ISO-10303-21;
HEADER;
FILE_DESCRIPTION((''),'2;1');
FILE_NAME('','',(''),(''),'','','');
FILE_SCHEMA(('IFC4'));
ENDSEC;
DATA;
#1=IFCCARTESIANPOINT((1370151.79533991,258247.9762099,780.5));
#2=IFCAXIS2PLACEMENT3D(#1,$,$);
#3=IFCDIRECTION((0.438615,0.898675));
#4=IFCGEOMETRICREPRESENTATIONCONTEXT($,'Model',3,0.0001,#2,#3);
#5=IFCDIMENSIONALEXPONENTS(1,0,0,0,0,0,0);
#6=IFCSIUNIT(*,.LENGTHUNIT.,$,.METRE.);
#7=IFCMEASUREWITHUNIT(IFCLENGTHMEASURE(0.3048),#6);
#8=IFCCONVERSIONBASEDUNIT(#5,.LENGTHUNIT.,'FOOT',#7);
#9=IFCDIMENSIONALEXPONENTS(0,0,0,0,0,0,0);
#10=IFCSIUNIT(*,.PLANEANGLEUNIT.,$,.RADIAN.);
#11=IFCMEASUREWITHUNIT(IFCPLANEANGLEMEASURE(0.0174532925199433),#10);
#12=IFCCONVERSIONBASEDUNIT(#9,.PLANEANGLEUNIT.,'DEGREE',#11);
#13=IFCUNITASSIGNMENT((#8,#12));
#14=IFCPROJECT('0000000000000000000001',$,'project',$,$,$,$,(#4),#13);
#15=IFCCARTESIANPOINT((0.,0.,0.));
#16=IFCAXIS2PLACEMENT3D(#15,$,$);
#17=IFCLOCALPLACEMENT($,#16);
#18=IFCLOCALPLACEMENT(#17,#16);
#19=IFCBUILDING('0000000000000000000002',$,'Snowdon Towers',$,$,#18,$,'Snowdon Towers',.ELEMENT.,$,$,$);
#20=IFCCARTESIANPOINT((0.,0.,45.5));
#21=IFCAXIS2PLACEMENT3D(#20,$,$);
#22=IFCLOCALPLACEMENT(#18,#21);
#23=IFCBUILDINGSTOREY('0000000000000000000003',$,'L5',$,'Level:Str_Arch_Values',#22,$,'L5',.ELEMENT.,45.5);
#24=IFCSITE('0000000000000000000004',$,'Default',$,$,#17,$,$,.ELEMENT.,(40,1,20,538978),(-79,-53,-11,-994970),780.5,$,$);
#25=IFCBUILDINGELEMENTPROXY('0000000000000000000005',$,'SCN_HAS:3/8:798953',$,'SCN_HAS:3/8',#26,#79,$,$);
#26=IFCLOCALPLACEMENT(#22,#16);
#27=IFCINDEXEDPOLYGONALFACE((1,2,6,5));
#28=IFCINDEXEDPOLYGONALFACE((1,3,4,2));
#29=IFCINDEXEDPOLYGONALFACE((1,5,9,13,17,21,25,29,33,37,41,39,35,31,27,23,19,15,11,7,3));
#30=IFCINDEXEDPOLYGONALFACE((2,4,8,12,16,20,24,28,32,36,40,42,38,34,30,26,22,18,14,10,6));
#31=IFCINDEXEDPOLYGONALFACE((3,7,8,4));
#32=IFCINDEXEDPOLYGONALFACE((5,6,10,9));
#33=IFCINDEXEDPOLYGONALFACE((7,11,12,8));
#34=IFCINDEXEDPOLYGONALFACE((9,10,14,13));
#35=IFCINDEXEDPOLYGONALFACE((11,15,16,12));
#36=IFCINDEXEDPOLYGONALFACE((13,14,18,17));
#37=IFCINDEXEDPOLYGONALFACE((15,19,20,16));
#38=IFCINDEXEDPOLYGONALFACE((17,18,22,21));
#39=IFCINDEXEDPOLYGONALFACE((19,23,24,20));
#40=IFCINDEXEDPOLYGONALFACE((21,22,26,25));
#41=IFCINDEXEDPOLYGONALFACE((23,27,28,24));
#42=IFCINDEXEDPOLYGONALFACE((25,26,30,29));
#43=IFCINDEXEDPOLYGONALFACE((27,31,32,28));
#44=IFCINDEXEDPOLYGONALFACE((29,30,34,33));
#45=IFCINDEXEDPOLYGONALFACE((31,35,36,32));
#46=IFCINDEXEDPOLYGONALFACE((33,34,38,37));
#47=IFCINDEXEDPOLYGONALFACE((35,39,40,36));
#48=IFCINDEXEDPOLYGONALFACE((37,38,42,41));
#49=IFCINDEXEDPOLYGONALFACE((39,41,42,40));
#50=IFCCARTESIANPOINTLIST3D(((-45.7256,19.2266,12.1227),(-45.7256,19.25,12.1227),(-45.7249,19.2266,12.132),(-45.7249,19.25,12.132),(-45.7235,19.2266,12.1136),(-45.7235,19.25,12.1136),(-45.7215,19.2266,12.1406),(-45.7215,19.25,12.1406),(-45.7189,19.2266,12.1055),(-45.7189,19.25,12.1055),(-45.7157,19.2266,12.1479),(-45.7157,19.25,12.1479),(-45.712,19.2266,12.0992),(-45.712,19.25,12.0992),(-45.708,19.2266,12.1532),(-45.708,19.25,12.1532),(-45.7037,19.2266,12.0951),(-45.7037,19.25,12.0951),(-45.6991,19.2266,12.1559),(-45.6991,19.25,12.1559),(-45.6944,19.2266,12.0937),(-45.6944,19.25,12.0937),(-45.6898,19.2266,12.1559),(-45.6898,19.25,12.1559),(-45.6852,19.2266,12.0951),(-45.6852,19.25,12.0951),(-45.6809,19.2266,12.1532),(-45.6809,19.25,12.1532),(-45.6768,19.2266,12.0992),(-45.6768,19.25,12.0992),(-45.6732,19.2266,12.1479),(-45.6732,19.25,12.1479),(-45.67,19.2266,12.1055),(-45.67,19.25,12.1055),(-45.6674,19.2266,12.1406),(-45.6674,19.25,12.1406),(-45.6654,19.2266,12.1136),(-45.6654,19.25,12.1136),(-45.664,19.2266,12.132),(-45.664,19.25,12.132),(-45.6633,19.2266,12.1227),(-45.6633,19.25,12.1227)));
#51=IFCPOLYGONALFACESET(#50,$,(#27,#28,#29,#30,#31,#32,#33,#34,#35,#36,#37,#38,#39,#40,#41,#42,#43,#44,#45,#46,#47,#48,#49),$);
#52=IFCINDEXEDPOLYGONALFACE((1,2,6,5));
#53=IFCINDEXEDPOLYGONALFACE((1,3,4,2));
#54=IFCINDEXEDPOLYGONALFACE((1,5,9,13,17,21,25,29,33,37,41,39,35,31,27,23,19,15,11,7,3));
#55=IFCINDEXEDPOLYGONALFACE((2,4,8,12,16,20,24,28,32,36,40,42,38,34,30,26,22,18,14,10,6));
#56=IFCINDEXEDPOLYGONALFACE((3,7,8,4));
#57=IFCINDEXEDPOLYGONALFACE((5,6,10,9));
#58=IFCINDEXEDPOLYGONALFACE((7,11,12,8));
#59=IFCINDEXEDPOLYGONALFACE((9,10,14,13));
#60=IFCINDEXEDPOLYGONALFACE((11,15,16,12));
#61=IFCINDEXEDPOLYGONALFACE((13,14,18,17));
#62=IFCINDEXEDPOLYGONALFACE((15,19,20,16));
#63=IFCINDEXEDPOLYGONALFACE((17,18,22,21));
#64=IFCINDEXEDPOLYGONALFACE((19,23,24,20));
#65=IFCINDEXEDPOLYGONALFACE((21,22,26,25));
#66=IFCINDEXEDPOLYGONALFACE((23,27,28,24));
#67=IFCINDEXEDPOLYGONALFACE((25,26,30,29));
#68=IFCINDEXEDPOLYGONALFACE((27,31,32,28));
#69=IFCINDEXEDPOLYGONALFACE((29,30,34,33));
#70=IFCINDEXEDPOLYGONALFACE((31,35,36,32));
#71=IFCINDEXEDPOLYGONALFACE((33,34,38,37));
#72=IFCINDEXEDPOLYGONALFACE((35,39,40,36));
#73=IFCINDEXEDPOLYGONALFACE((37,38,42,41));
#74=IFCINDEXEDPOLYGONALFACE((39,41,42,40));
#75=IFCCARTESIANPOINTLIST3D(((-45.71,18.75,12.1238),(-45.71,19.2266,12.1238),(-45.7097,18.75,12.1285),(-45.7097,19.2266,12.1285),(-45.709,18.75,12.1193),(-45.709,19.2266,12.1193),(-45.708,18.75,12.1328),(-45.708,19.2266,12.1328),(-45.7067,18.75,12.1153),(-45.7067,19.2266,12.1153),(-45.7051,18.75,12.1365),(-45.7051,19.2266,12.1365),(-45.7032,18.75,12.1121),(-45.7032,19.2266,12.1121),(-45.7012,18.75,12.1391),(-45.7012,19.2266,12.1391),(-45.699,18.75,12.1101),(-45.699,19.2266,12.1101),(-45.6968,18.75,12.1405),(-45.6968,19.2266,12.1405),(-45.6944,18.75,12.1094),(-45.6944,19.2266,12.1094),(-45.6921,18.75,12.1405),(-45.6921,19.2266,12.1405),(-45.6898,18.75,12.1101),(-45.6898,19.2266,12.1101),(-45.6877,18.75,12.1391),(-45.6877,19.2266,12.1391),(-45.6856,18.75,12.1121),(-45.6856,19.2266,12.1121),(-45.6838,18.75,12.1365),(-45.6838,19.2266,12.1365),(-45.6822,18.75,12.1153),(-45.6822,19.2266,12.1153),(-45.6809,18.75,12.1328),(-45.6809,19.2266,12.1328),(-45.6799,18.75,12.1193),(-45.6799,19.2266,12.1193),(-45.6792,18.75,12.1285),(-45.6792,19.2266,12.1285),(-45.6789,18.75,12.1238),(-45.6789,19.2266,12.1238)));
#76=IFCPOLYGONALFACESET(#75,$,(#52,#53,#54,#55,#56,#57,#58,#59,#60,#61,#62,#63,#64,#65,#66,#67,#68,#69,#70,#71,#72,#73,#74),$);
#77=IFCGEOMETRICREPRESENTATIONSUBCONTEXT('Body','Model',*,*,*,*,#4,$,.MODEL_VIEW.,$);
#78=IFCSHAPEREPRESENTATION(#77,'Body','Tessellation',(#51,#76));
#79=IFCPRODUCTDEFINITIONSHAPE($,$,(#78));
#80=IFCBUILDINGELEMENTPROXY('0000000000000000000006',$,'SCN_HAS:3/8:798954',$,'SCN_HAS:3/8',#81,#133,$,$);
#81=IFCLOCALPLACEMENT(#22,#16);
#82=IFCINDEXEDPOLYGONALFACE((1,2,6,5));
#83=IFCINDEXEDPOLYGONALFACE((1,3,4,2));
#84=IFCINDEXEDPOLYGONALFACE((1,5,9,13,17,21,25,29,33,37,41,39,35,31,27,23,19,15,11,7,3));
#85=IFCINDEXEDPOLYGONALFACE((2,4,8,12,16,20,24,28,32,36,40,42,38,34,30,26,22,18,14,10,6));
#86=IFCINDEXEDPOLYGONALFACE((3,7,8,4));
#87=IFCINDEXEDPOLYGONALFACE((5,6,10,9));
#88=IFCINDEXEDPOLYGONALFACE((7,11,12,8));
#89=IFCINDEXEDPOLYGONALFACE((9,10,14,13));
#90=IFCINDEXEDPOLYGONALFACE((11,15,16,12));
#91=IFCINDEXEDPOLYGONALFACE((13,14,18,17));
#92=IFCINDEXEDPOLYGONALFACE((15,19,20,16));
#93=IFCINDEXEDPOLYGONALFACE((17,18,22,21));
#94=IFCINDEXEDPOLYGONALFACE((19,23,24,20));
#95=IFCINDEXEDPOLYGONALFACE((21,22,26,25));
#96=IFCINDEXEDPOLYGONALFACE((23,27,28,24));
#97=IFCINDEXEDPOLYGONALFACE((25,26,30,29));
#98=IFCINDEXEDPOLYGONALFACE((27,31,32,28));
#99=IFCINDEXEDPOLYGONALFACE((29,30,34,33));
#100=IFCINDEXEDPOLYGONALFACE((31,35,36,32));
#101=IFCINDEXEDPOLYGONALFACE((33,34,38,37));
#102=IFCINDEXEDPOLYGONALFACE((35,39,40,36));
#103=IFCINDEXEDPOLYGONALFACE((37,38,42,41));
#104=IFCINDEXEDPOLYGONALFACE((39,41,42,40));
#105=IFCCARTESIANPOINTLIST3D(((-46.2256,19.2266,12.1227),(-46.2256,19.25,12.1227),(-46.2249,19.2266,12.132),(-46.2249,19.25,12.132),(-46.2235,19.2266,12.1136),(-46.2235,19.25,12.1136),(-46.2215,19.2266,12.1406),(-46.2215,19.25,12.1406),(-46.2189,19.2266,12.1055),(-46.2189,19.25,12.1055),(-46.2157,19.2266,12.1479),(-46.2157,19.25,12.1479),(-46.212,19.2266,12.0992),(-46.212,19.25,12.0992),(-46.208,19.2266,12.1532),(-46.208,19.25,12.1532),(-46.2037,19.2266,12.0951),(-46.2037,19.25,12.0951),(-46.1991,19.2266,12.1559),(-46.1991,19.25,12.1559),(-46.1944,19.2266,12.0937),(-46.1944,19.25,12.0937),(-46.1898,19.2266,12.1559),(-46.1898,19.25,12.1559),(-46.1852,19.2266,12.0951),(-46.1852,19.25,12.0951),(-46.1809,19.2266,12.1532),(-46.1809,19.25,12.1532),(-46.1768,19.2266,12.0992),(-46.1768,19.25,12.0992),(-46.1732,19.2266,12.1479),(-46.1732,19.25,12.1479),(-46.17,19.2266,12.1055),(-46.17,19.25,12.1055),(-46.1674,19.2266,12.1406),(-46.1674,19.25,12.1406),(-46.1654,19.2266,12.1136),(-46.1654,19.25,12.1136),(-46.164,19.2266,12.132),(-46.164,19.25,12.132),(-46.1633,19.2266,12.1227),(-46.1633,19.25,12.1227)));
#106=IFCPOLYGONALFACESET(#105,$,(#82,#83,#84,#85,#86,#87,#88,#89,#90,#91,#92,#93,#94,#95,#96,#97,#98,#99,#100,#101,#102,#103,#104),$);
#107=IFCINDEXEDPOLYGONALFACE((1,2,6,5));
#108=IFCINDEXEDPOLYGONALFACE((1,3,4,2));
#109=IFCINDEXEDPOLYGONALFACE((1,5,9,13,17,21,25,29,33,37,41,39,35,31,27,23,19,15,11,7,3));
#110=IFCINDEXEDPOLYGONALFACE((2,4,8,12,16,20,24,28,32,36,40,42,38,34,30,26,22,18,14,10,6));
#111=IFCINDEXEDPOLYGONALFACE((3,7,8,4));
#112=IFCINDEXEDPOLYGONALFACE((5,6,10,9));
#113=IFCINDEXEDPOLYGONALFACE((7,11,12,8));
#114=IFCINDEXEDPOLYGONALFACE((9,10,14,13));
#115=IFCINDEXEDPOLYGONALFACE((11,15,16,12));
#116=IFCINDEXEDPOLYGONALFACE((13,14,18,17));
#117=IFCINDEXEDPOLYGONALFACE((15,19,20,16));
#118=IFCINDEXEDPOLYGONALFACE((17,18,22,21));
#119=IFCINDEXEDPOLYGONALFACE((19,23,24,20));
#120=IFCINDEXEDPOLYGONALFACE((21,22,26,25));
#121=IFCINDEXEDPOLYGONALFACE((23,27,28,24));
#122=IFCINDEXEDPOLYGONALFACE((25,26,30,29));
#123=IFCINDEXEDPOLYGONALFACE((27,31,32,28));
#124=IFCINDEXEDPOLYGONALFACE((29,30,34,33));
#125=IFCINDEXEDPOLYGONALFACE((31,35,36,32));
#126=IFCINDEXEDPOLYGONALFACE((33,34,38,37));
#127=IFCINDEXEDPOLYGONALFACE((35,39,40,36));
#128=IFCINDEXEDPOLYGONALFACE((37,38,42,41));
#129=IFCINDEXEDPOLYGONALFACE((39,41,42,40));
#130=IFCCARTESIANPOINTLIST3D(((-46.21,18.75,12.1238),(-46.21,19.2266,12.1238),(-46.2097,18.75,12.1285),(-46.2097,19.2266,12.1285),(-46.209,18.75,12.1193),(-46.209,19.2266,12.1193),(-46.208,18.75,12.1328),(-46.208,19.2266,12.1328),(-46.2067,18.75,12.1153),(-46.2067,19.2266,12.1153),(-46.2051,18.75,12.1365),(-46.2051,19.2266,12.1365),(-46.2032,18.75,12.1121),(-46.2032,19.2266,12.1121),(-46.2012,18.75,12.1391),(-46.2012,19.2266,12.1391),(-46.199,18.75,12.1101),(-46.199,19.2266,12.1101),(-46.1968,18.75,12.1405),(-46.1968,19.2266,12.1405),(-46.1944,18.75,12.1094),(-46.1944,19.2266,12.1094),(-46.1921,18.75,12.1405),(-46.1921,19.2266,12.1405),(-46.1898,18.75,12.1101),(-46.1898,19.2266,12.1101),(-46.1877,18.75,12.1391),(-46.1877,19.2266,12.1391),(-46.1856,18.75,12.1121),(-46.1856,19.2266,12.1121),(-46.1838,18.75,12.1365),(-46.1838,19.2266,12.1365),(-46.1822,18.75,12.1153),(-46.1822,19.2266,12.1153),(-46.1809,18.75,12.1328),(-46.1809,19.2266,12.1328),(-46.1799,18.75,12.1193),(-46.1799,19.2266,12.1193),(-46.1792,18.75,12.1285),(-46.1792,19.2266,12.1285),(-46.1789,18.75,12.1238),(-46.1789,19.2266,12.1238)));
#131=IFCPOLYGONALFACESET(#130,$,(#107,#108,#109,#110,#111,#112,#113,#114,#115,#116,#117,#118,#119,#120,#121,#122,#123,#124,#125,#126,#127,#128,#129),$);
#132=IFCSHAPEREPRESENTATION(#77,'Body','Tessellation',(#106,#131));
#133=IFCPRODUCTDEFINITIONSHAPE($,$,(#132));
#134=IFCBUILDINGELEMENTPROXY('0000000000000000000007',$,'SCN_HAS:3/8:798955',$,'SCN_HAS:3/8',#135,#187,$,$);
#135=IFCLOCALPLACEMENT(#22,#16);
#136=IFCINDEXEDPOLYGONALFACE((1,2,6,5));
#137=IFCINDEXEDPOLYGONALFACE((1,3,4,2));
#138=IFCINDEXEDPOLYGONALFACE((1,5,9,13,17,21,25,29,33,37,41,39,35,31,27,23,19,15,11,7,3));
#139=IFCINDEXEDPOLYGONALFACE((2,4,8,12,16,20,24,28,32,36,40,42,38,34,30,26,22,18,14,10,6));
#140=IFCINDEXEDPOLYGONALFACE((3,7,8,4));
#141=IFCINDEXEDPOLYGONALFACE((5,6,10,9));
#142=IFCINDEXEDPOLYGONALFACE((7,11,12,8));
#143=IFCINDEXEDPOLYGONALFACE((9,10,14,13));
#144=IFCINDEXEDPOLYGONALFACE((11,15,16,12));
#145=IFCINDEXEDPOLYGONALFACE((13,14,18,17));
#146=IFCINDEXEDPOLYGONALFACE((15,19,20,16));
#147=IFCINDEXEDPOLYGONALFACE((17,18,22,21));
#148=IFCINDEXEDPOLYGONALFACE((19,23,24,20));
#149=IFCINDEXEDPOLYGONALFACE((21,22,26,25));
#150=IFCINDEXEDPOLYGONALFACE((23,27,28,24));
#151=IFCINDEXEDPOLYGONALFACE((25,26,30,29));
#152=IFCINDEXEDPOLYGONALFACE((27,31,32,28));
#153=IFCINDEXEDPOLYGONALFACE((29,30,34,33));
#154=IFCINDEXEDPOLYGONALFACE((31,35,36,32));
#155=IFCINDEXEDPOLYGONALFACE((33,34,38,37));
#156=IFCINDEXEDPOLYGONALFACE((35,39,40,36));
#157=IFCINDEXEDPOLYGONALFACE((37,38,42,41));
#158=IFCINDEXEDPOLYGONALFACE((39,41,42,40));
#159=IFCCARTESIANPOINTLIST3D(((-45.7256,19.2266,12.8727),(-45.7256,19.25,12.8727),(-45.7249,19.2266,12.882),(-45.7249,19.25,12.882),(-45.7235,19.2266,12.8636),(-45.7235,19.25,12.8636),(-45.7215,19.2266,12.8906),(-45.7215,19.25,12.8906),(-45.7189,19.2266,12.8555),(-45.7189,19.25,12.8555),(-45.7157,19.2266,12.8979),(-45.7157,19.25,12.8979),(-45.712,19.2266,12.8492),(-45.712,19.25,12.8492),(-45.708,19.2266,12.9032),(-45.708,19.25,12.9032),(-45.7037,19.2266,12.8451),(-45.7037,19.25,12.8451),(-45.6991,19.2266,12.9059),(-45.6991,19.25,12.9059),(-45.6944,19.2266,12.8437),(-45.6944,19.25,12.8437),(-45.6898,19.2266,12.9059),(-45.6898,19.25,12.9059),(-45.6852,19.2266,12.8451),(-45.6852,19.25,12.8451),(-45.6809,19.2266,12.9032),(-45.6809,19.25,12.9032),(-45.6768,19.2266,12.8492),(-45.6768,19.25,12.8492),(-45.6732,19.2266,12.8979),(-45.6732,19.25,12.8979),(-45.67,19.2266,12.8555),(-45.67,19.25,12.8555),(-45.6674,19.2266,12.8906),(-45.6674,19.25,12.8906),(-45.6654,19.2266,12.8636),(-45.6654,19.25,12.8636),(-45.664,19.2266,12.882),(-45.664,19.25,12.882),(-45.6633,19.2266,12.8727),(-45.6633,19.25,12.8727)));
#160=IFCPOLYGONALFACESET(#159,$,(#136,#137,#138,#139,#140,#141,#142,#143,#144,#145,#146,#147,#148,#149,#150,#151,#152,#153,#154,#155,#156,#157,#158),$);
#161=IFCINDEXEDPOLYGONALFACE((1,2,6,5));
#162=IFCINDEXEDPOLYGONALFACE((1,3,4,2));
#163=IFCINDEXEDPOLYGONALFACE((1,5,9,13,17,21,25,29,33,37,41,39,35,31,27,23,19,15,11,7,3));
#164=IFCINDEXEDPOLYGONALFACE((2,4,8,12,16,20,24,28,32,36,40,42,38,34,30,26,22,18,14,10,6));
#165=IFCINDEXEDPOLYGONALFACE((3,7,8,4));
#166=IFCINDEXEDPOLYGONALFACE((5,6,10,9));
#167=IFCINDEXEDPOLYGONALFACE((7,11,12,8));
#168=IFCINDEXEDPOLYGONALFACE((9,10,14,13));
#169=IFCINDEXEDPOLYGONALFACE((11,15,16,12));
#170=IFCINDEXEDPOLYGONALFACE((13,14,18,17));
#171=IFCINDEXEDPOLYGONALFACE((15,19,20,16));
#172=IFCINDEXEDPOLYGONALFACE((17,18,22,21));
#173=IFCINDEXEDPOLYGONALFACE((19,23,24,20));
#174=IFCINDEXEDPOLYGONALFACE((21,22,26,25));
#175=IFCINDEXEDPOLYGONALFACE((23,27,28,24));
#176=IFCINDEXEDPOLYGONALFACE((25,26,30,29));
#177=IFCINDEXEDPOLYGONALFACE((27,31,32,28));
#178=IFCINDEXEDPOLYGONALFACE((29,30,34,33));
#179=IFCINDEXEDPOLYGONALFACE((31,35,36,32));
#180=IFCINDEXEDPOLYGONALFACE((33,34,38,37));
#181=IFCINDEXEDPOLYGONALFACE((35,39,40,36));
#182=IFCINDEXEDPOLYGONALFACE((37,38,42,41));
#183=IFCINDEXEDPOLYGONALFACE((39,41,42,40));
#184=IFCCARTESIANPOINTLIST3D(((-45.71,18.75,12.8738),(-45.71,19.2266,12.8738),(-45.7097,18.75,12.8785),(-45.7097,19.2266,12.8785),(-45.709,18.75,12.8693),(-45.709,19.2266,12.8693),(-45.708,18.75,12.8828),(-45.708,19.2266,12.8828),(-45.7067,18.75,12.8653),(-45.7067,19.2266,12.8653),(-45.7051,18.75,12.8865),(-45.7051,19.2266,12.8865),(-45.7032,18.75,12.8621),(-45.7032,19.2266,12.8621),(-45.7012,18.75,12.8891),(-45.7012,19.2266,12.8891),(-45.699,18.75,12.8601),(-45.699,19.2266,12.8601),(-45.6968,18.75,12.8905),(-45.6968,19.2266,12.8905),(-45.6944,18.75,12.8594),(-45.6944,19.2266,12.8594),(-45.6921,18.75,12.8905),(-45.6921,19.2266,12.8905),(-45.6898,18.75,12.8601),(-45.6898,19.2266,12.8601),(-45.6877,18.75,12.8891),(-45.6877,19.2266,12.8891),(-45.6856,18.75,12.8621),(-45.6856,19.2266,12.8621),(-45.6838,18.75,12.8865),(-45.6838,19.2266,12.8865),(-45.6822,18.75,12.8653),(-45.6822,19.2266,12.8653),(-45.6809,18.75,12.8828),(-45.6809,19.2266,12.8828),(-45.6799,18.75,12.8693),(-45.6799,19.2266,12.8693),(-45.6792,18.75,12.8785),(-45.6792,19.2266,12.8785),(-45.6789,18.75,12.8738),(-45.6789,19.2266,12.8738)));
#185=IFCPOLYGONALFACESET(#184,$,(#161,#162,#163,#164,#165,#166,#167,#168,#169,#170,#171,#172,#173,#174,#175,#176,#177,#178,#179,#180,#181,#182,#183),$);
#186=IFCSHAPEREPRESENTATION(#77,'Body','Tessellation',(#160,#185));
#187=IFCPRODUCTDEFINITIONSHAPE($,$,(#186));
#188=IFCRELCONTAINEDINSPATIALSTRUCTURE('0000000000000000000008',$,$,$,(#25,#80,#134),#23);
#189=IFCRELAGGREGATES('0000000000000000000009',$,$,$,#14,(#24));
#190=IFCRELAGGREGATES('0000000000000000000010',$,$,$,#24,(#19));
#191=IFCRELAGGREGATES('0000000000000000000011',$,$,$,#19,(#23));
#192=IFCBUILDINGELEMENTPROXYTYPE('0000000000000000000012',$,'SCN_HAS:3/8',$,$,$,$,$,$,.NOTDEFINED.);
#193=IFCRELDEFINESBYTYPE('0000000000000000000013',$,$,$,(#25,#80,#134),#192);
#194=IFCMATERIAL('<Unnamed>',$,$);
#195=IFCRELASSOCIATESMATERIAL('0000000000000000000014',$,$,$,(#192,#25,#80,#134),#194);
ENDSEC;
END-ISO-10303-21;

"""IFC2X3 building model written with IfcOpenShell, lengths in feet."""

from ifc_helpers import new_model, entity, si_unit, converted_unit, direction, frame, frame_2d, origin, place, context, subcontext, project, spatial, circle, extrude, source, transform, mapped, material, type_object, type_shapes, element, save


model = new_model("IFC2X3")

# Units and contexts
model_context = context("Model", 3, precision=0.0001, world=frame((1370151.79533991, 258247.9762099, 780.5)), true_north=direction((0.438615, 0.898675)))
body_context = subcontext(model_context, "Body", "Model", "MODEL_VIEW")
ifc_project = project(units=[converted_unit("LENGTHUNIT", "FOOT", entity("IfcLengthMeasure", 0.3048), si_unit("LENGTHUNIT", "METRE"), dimensions=[1, 0, 0, 0, 0, 0, 0]), converted_unit("PLANEANGLEUNIT", "DEGREE", entity("IfcPlaneAngleMeasure", 0.0174532925199433), si_unit("PLANEANGLEUNIT", "RADIAN"), dimensions=[0, 0, 0, 0, 0, 0, 0])], contexts=[model_context])

# Site, building, storey
site_placement = place(None, origin())
site = spatial("IfcSite", under=ifc_project, at=site_placement, Name="Default", CompositionType="ELEMENT", RefLatitude=(40, 1, 20, 538978), RefLongitude=(-79, -53, -11, -994970), RefElevation=780.5)
building_placement = place(site_placement, origin())
building = spatial("IfcBuilding", under=site, at=building_placement, Name="Snowdon Towers", LongName="Snowdon Towers", CompositionType="ELEMENT")
storey_placement = place(building_placement, frame((0.0, 0.0, 45.5)))
storey = spatial("IfcBuildingStorey", under=building, at=storey_placement, Name="L5", ObjectType="Level:Str_Arch_Values", LongName="L5", CompositionType="ELEMENT", Elevation=45.5)

# Building element proxies
ifc_material_1 = material(Name="<Unnamed>")
building_element_proxy_type = type_object("IfcBuildingElementProxyType", Name="SCN_HAS:3/8", PredefinedType="NOTDEFINED", material=ifc_material_1)
shared_shape = source(origin(), body_context, "Body", "SweptSolid", [
    extrude(circle(Radius=0.0312, at=frame_2d((0.0, 0.0), x_axis=(1.0, 0.0))), frame((0.0, 0.0, -0.5), z_axis=(0.0, 0.0, 1.0), x_axis=(0.0, -1.0, 0.0)), (0.0, 0.0, 1.0), 0.0234),
    extrude(circle(Radius=0.0156, at=frame_2d((0.0, 0.0), x_axis=(1.0, 0.0))), frame((0.0, 0.0, -0.4766), z_axis=(0.0, 0.0, 1.0), x_axis=(0.0, -1.0, 0.0)), (0.0, 0.0, 1.0), 0.4766),
])
type_shapes(building_element_proxy_type, [shared_shape])
for number, where, z_axis, x_axis, name in (
    (1, (-45.6944, 18.75, 12.125), (0.0, -1.0, 0.0), (1.0, 0.0, 0.0), "SCN_HAS:3/8:798953"),
    (2, (-46.1944, 18.75, 12.125), (0.0, -1.0, 0.0), (1.0, 0.0, 0.0), "SCN_HAS:3/8:798954"),
    (3, (-45.6944, 18.75, 12.875), (0.0, -1.0, 0.0), (1.0, 0.0, 0.0), "SCN_HAS:3/8:798955"),
):
    element("IfcBuildingElementProxy", number, at=place(storey_placement, frame(where, z_axis=z_axis, x_axis=x_axis)), inside=storey, type_object=building_element_proxy_type, material=ifc_material_1, Name=name, ObjectType="SCN_HAS:3/8", context=body_context, shape_type="MappedRepresentation", body=[
        mapped(shared_shape, transform((0.0, 0.0, 0.0), scale=1.0)),
    ])

save(model, "model.ifc")
